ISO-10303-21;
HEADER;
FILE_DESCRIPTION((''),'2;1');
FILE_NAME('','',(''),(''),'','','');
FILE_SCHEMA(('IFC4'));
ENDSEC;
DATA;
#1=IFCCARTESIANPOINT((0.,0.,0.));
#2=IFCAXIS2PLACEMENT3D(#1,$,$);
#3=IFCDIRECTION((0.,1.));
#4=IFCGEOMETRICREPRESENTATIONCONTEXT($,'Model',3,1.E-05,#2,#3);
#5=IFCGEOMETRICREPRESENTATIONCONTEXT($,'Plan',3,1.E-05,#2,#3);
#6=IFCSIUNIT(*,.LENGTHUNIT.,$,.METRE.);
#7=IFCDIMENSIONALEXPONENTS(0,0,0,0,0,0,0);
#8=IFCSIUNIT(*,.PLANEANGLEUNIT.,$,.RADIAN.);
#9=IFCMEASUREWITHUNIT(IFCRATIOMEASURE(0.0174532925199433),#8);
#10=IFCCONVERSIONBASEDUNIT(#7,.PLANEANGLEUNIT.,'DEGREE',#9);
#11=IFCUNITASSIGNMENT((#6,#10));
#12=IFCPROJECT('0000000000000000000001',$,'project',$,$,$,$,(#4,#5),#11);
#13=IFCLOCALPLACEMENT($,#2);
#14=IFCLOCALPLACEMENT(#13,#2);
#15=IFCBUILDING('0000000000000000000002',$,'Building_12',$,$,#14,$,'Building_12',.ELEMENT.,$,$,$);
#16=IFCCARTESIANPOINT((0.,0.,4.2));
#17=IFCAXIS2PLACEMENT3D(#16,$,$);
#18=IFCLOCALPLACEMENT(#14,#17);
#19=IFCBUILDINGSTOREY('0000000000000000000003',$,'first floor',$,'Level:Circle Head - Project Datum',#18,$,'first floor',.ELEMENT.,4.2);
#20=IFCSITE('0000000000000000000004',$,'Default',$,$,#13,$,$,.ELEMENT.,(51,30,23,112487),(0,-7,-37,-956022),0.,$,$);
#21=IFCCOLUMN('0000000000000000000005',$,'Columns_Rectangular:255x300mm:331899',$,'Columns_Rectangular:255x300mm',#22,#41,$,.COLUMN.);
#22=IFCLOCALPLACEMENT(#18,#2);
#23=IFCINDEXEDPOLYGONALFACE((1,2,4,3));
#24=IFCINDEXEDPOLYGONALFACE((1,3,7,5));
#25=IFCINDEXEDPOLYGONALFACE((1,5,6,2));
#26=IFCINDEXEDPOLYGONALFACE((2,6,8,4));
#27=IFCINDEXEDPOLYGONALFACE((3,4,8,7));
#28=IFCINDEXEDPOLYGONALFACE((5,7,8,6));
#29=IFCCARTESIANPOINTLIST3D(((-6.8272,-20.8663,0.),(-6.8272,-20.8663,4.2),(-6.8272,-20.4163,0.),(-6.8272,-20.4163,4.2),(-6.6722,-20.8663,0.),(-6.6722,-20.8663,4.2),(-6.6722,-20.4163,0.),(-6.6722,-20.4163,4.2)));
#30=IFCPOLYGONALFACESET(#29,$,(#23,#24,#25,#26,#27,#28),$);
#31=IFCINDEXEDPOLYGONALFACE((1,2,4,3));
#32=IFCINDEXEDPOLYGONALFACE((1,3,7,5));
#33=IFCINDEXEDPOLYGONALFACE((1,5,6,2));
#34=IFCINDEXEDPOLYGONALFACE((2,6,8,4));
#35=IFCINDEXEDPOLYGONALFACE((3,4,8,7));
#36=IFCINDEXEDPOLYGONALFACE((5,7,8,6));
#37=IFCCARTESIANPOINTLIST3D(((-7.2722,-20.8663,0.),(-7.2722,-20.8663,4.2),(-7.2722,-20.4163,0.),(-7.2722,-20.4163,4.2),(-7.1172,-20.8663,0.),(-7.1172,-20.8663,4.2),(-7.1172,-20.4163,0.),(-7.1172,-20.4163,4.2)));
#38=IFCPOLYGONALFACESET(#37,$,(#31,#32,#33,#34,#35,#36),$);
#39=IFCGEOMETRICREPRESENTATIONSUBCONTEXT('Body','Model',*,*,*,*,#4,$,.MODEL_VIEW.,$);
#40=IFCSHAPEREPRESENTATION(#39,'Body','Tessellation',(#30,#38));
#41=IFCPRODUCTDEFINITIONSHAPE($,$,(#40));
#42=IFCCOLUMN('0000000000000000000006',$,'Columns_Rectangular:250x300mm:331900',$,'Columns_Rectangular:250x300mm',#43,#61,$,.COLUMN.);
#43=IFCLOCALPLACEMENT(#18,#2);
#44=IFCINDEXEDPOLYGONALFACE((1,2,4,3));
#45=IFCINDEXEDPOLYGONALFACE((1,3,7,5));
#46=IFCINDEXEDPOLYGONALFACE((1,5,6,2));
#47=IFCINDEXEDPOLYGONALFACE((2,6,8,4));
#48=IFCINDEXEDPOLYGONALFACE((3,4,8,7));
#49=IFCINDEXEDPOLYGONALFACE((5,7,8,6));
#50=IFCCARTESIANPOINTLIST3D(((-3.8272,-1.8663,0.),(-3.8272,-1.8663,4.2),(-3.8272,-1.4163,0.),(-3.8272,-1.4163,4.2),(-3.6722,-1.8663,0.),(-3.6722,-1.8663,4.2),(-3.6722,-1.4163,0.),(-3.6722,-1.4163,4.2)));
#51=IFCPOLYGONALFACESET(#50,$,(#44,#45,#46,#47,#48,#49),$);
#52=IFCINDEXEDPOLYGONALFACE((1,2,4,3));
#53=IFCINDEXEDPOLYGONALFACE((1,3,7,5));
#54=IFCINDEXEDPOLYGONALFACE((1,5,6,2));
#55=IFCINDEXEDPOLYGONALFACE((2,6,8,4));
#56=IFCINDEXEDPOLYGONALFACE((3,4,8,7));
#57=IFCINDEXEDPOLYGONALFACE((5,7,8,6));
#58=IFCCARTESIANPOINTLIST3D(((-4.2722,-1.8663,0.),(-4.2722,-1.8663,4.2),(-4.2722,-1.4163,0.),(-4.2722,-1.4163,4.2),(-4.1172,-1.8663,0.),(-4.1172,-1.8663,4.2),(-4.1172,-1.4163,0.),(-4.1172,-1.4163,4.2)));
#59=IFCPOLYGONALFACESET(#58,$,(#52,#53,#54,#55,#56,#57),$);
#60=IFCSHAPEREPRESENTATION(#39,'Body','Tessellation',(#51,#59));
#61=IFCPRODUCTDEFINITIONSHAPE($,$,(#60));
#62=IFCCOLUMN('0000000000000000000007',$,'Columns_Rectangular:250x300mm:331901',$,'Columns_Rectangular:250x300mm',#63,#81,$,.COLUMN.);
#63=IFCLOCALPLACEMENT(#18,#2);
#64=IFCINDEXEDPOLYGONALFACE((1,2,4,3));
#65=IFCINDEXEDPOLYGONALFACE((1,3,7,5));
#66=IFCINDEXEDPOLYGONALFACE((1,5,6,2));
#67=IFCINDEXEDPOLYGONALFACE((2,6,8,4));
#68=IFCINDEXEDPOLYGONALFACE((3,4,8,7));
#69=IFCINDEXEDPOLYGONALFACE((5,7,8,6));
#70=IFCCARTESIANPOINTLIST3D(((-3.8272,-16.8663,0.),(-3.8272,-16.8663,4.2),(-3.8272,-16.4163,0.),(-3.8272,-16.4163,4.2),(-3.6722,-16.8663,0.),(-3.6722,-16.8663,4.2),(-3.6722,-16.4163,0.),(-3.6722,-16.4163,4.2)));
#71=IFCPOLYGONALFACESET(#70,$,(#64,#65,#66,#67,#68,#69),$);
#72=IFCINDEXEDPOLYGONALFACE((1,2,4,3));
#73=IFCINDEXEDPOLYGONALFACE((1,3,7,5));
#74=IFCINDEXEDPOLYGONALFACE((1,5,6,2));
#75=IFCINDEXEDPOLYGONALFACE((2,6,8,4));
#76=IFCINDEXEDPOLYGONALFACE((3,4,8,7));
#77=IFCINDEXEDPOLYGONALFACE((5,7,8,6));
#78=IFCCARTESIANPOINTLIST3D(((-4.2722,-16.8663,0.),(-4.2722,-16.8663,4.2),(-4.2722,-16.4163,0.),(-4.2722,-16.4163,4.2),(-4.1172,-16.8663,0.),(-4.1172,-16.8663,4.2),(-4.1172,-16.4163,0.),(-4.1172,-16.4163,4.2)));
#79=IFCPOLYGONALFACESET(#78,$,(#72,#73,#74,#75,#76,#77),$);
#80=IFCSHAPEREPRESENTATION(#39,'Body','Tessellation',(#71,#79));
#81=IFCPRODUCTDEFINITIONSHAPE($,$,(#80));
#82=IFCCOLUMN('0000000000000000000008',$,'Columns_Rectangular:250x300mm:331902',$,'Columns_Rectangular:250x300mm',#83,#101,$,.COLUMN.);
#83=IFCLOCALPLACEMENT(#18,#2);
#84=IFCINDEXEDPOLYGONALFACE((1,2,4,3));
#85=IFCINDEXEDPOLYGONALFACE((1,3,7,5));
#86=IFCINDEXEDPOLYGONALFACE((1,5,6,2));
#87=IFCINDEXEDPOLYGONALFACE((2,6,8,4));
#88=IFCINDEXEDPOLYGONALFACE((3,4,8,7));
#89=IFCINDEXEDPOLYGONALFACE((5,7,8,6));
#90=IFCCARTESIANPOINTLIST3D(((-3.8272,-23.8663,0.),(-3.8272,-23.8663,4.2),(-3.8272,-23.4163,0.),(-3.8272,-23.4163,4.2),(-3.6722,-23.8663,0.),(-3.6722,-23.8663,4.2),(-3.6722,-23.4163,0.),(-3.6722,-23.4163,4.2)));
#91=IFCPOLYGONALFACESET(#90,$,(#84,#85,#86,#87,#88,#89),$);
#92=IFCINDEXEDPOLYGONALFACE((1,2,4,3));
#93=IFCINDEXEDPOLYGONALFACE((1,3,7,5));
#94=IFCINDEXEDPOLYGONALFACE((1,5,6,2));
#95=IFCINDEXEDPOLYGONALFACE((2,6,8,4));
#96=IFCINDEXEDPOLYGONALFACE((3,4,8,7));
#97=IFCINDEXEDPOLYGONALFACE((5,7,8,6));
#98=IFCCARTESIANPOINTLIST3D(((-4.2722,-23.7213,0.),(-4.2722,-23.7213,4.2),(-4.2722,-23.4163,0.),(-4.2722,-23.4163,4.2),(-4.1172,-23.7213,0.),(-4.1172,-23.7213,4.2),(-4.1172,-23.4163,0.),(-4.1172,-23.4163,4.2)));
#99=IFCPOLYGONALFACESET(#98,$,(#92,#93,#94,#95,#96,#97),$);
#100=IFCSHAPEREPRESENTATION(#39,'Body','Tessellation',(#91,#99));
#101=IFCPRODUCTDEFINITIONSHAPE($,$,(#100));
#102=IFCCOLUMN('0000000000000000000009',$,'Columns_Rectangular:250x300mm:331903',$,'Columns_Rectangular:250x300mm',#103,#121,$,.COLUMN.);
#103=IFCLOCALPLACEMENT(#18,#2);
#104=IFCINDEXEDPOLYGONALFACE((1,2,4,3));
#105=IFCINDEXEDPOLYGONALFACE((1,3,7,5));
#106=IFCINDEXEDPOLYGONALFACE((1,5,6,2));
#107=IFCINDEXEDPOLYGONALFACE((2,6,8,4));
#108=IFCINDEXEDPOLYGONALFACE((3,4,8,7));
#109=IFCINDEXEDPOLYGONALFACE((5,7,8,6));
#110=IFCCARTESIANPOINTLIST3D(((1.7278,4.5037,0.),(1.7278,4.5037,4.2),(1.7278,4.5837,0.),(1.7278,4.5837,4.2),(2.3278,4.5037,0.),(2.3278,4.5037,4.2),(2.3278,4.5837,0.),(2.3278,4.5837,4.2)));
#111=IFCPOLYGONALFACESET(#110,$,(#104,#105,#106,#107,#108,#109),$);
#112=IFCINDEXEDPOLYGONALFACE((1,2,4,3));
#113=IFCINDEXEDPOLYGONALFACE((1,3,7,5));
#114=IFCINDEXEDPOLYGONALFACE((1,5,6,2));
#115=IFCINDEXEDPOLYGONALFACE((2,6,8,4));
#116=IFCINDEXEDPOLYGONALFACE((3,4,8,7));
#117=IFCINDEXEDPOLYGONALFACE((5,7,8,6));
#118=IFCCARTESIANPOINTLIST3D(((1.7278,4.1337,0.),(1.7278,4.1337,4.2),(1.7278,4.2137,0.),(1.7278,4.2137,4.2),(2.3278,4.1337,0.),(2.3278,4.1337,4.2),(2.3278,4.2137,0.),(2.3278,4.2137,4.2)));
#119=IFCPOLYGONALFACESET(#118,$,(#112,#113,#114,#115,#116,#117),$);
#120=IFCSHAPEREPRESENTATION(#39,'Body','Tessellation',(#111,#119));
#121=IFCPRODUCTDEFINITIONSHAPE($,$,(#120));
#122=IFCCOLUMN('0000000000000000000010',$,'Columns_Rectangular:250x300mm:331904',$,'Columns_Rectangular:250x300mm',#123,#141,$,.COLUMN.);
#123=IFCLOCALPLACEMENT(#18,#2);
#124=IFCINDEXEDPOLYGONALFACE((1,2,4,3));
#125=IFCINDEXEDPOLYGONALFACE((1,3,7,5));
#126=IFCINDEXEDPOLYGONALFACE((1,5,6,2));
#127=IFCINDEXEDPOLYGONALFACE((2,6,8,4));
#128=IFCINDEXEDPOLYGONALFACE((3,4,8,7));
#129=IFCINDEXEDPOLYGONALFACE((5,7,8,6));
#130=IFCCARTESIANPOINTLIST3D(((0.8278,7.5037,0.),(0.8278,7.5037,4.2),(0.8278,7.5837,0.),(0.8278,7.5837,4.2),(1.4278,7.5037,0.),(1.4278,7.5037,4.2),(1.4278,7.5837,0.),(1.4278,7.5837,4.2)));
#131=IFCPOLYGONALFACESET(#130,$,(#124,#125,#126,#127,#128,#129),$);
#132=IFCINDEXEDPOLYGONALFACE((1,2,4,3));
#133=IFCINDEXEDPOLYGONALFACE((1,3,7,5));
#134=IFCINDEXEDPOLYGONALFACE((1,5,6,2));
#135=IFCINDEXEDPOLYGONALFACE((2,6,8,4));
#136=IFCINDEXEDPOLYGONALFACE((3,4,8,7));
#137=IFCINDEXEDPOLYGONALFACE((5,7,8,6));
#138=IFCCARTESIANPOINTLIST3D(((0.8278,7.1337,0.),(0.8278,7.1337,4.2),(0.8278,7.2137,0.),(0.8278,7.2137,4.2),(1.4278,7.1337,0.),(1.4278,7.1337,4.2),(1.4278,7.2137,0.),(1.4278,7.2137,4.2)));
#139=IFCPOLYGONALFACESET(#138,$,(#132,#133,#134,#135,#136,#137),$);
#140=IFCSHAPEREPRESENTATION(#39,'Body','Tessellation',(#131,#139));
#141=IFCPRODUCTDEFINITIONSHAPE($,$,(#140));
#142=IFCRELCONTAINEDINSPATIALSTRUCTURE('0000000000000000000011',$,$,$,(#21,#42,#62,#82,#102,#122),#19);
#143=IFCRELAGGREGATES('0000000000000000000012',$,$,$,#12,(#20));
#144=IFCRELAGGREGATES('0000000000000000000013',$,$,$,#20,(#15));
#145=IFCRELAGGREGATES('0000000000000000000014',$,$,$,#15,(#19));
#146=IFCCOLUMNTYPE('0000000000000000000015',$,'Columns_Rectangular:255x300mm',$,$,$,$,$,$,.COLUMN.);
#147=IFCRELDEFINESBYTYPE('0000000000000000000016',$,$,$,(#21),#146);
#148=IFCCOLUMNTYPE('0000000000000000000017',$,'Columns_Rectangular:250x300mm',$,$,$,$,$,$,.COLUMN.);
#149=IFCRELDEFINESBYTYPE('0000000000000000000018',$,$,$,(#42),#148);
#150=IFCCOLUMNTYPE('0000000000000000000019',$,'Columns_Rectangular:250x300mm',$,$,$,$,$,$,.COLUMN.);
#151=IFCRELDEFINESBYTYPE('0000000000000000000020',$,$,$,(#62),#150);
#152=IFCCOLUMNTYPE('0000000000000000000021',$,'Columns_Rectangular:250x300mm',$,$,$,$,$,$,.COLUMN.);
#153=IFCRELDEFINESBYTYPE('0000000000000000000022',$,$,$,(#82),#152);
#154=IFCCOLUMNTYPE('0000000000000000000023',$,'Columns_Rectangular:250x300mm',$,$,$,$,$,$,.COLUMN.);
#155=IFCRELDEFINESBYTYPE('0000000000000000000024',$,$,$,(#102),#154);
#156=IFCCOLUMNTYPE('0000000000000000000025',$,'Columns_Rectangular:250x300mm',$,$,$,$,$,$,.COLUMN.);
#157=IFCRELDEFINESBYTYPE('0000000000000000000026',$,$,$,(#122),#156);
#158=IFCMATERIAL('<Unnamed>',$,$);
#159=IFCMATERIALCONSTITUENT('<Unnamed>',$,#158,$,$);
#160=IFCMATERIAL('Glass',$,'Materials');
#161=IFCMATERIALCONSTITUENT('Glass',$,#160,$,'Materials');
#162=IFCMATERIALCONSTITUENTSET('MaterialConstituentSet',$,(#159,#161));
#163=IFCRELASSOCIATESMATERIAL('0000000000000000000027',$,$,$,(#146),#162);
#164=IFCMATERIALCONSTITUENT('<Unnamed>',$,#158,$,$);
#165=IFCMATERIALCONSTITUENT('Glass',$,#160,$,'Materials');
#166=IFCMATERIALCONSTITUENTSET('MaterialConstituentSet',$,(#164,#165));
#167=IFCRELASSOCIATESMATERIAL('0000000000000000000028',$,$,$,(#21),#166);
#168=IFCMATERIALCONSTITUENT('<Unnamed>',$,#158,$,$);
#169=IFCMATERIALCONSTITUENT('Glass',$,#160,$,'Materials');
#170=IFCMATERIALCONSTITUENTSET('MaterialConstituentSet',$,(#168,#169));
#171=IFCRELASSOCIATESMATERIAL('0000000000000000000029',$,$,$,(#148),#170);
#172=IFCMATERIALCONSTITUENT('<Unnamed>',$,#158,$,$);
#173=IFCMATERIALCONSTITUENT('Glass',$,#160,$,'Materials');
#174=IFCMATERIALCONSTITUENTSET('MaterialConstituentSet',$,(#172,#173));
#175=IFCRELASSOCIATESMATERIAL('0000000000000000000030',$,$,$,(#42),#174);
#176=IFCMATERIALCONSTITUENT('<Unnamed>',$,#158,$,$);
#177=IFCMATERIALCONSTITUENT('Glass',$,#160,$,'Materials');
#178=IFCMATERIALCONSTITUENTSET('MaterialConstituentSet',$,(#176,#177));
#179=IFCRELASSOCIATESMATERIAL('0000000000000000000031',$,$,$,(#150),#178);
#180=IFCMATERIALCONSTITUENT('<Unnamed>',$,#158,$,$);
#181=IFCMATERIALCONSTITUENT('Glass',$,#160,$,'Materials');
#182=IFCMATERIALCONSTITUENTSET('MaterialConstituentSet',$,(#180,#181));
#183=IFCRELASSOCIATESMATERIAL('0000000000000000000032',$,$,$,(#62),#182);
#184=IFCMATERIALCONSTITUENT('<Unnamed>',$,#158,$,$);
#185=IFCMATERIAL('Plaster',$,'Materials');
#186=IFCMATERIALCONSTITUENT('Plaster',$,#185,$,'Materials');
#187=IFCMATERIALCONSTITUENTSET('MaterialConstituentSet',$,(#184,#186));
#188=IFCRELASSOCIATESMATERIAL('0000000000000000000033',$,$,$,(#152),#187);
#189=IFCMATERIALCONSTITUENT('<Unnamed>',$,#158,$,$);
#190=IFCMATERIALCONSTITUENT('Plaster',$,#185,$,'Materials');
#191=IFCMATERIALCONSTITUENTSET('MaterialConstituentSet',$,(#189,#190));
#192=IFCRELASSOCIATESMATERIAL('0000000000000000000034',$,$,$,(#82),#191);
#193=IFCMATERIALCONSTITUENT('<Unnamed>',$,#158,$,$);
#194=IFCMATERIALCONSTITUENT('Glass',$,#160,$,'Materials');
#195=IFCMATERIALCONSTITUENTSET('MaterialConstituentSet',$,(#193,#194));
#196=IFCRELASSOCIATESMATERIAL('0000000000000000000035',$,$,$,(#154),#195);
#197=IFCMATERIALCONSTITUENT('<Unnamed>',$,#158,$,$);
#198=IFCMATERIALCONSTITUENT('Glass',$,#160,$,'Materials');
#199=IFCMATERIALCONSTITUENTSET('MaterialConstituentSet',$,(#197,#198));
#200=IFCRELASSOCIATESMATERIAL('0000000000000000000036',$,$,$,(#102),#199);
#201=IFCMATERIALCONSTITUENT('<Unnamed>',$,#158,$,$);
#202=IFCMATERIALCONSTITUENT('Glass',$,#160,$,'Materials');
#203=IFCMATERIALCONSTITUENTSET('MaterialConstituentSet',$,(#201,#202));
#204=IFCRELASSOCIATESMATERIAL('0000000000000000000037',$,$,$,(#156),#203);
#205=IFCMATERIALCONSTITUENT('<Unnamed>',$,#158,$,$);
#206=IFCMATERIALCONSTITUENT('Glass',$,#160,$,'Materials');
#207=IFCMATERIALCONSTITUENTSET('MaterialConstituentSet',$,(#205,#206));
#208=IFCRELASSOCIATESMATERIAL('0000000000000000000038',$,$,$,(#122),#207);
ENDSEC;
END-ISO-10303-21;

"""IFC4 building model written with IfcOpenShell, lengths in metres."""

from ifc_helpers import new_model, entity, si_unit, converted_unit, direction, frame, origin, place, context, subcontext, project, spatial, indexed_curve, outline, extrude, source, transform, mapped, material, constituent, constituent_set, type_object, type_shapes, element, save


model = new_model("IFC4")

# Units and contexts
model_context = context("Model", 3, precision=1e-05, world=origin(), true_north=direction((0.0, 1.0)))
plan_context = context("Plan", 3, precision=1e-05, world=origin(), true_north=direction((0.0, 1.0)))
body_context = subcontext(model_context, "Body", "Model", "MODEL_VIEW")
ifc_project = project(units=[si_unit("LENGTHUNIT", "METRE"), converted_unit("PLANEANGLEUNIT", "DEGREE", entity("IfcRatioMeasure", 0.0174532925199433), si_unit("PLANEANGLEUNIT", "RADIAN"), dimensions=[0, 0, 0, 0, 0, 0, 0])], contexts=[model_context, plan_context])

# Site, building, storey
site_placement = place(None, origin())
site = spatial("IfcSite", under=ifc_project, at=site_placement, Name="Default", CompositionType="ELEMENT", RefLatitude=(51, 30, 23, 112487), RefLongitude=(0, -7, -37, -956022), RefElevation=0.0)
building_placement = place(site_placement, origin())
building = spatial("IfcBuilding", under=site, at=building_placement, Name="Building_12", LongName="Building_12", CompositionType="ELEMENT")
storey_placement = place(building_placement, frame((0.0, 0.0, 4.2)))
storey = spatial("IfcBuildingStorey", under=building, at=storey_placement, Name="first floor", ObjectType="Level:Circle Head - Project Datum", LongName="first floor", CompositionType="ELEMENT", Elevation=4.2)

# Columns
ifc_material_1 = material(Name="<Unnamed>")
ifc_constituent_1 = constituent(ifc_material_1, Name="<Unnamed>")
ifc_material_2 = material(Name="Glass", Category="Materials")
ifc_constituent_2 = constituent(ifc_material_2, Name="Glass", Category="Materials")
ifc_constituent_set_1 = constituent_set(constituents=[ifc_constituent_1, ifc_constituent_2], Name="MaterialConstituentSet")
ifc_constituent_3 = constituent(ifc_material_1, Name="<Unnamed>")
ifc_constituent_4 = constituent(ifc_material_2, Name="Glass", Category="Materials")
ifc_constituent_set_2 = constituent_set(constituents=[ifc_constituent_3, ifc_constituent_4], Name="MaterialConstituentSet")
column_type_1 = type_object("IfcColumnType", Name="Columns_Rectangular:255x300mm", PredefinedType="COLUMN", material=ifc_constituent_set_2)
shared_shape_1 = source(origin(), body_context, "Body", "SweptSolid", [
    extrude(outline(indexed_curve([(-0.225, -0.0775), (0.225, -0.0775), (0.225, 0.0775), (-0.225, 0.0775), (-0.225, -0.0775)], self_intersect=False)), frame((-6.7497, -20.6413, 4.2), z_axis=(0.0, 0.0, 1.0), x_axis=(0.0, -1.0, 0.0)), (0.0, 0.0, 1.0), 4.2),
    extrude(outline(indexed_curve([(-0.225, -0.0775), (0.225, -0.0775), (0.225, 0.0775), (-0.225, 0.0775), (-0.225, -0.0775)], self_intersect=False)), frame((-7.1947, -20.6413, 4.2), z_axis=(0.0, 0.0, 1.0), x_axis=(0.0, -1.0, 0.0)), (0.0, 0.0, 1.0), 4.2),
])
type_shapes(column_type_1, [shared_shape_1])
column_1_placement = place(storey_placement, frame((0.0, 0.0, -4.2)))
element("IfcColumn", 1, at=column_1_placement, inside=storey, type_object=column_type_1, material=ifc_constituent_set_1, Name="Columns_Rectangular:255x300mm:331899", ObjectType="Columns_Rectangular:255x300mm", PredefinedType="COLUMN", context=body_context, shape_type="MappedRepresentation", body=[
    mapped(shared_shape_1, transform((0.0, 0.0, 0.0), scale=1.0)),
])
ifc_constituent_5 = constituent(ifc_material_1, Name="<Unnamed>")
ifc_constituent_6 = constituent(ifc_material_2, Name="Glass", Category="Materials")
ifc_constituent_set_3 = constituent_set(constituents=[ifc_constituent_5, ifc_constituent_6], Name="MaterialConstituentSet")
ifc_constituent_7 = constituent(ifc_material_1, Name="<Unnamed>")
ifc_constituent_8 = constituent(ifc_material_2, Name="Glass", Category="Materials")
ifc_constituent_set_4 = constituent_set(constituents=[ifc_constituent_7, ifc_constituent_8], Name="MaterialConstituentSet")
column_type_2 = type_object("IfcColumnType", Name="Columns_Rectangular:250x300mm", PredefinedType="COLUMN", material=ifc_constituent_set_4)
shared_shape_2 = source(origin(), body_context, "Body", "SweptSolid", [
    extrude(outline(indexed_curve([(-0.225, -0.0775), (0.225, -0.0775), (0.225, 0.0775), (-0.225, 0.0775), (-0.225, -0.0775)], self_intersect=False)), frame((-3.7497, -1.6413, 4.2), z_axis=(0.0, 0.0, 1.0), x_axis=(0.0, -1.0, 0.0)), (0.0, 0.0, 1.0), 4.2),
    extrude(outline(indexed_curve([(-0.225, -0.0775), (0.225, -0.0775), (0.225, 0.0775), (-0.225, 0.0775), (-0.225, -0.0775)], self_intersect=False)), frame((-4.1947, -1.6413, 4.2), z_axis=(0.0, 0.0, 1.0), x_axis=(0.0, -1.0, 0.0)), (0.0, 0.0, 1.0), 4.2),
])
type_shapes(column_type_2, [shared_shape_2])
column_2_placement = place(storey_placement, frame((0.0, 0.0, -4.2)))
element("IfcColumn", 2, at=column_2_placement, inside=storey, type_object=column_type_2, material=ifc_constituent_set_3, Name="Columns_Rectangular:250x300mm:331900", ObjectType="Columns_Rectangular:250x300mm", PredefinedType="COLUMN", context=body_context, shape_type="MappedRepresentation", body=[
    mapped(shared_shape_2, transform((0.0, 0.0, 0.0), scale=1.0)),
])
ifc_constituent_9 = constituent(ifc_material_1, Name="<Unnamed>")
ifc_constituent_10 = constituent(ifc_material_2, Name="Glass", Category="Materials")
ifc_constituent_set_5 = constituent_set(constituents=[ifc_constituent_9, ifc_constituent_10], Name="MaterialConstituentSet")
ifc_constituent_11 = constituent(ifc_material_1, Name="<Unnamed>")
ifc_constituent_12 = constituent(ifc_material_2, Name="Glass", Category="Materials")
ifc_constituent_set_6 = constituent_set(constituents=[ifc_constituent_11, ifc_constituent_12], Name="MaterialConstituentSet")
column_type_3 = type_object("IfcColumnType", Name="Columns_Rectangular:250x300mm", PredefinedType="COLUMN", material=ifc_constituent_set_6)
shared_shape_3 = source(origin(), body_context, "Body", "SweptSolid", [
    extrude(outline(indexed_curve([(-0.225, -0.0775), (0.225, -0.0775), (0.225, 0.0775), (-0.225, 0.0775), (-0.225, -0.0775)], self_intersect=False)), frame((-3.7497, -16.6413, 4.2), z_axis=(0.0, 0.0, 1.0), x_axis=(0.0, -1.0, 0.0)), (0.0, 0.0, 1.0), 4.2),
    extrude(outline(indexed_curve([(-0.225, -0.0775), (0.225, -0.0775), (0.225, 0.0775), (-0.225, 0.0775), (-0.225, -0.0775)], self_intersect=False)), frame((-4.1947, -16.6413, 4.2), z_axis=(0.0, 0.0, 1.0), x_axis=(0.0, -1.0, 0.0)), (0.0, 0.0, 1.0), 4.2),
])
type_shapes(column_type_3, [shared_shape_3])
column_3_placement = place(storey_placement, frame((0.0, 0.0, -4.2)))
element("IfcColumn", 3, at=column_3_placement, inside=storey, type_object=column_type_3, material=ifc_constituent_set_5, Name="Columns_Rectangular:250x300mm:331901", ObjectType="Columns_Rectangular:250x300mm", PredefinedType="COLUMN", context=body_context, shape_type="MappedRepresentation", body=[
    mapped(shared_shape_3, transform((0.0, 0.0, 0.0), scale=1.0)),
])
ifc_constituent_13 = constituent(ifc_material_1, Name="<Unnamed>")
ifc_material_3 = material(Name="Plaster", Category="Materials")
ifc_constituent_14 = constituent(ifc_material_3, Name="Plaster", Category="Materials")
ifc_constituent_set_7 = constituent_set(constituents=[ifc_constituent_13, ifc_constituent_14], Name="MaterialConstituentSet")
ifc_constituent_15 = constituent(ifc_material_1, Name="<Unnamed>")
ifc_constituent_16 = constituent(ifc_material_3, Name="Plaster", Category="Materials")
ifc_constituent_set_8 = constituent_set(constituents=[ifc_constituent_15, ifc_constituent_16], Name="MaterialConstituentSet")
column_type_4 = type_object("IfcColumnType", Name="Columns_Rectangular:250x300mm", PredefinedType="COLUMN", material=ifc_constituent_set_8)
shared_shape_4 = source(origin(), body_context, "Body", "SweptSolid", [
    extrude(outline(indexed_curve([(-0.225, -0.0775), (0.225, -0.0775), (0.225, 0.0775), (-0.225, 0.0775), (-0.225, -0.0775)], self_intersect=False)), frame((-3.7497, -23.6413, 4.2), z_axis=(0.0, 0.0, 1.0), x_axis=(0.0, -1.0, 0.0)), (0.0, 0.0, 1.0), 4.2),
    extrude(outline(indexed_curve([(-0.1525, -0.0775), (0.1525, -0.0775), (0.1525, 0.0775), (-0.1525, 0.0775), (-0.1525, -0.0775)], self_intersect=False)), frame((-4.1947, -23.5688, 4.2), z_axis=(0.0, 0.0, 1.0), x_axis=(0.0, -1.0, 0.0)), (0.0, 0.0, 1.0), 4.2),
])
type_shapes(column_type_4, [shared_shape_4])
column_4_placement = place(storey_placement, frame((0.0, 0.0, -4.2)))
element("IfcColumn", 4, at=column_4_placement, inside=storey, type_object=column_type_4, material=ifc_constituent_set_7, Name="Columns_Rectangular:250x300mm:331902", ObjectType="Columns_Rectangular:250x300mm", PredefinedType="COLUMN", context=body_context, shape_type="MappedRepresentation", body=[
    mapped(shared_shape_4, transform((0.0, 0.0, 0.0), scale=1.0)),
])
ifc_constituent_17 = constituent(ifc_material_1, Name="<Unnamed>")
ifc_constituent_18 = constituent(ifc_material_2, Name="Glass", Category="Materials")
ifc_constituent_set_9 = constituent_set(constituents=[ifc_constituent_17, ifc_constituent_18], Name="MaterialConstituentSet")
ifc_constituent_19 = constituent(ifc_material_1, Name="<Unnamed>")
ifc_constituent_20 = constituent(ifc_material_2, Name="Glass", Category="Materials")
ifc_constituent_set_10 = constituent_set(constituents=[ifc_constituent_19, ifc_constituent_20], Name="MaterialConstituentSet")
column_type_5 = type_object("IfcColumnType", Name="Columns_Rectangular:250x300mm", PredefinedType="COLUMN", material=ifc_constituent_set_10)
shared_shape_5 = source(origin(), body_context, "Body", "SweptSolid", [
    extrude(outline(indexed_curve([(-0.04, -0.3), (0.04, -0.3), (0.04, 0.3), (-0.04, 0.3), (-0.04, -0.3)], self_intersect=False)), frame((2.0278, 4.5437, 4.2), z_axis=(0.0, 0.0, 1.0), x_axis=(0.0, -1.0, 0.0)), (0.0, 0.0, 1.0), 4.2),
    extrude(outline(indexed_curve([(-0.04, -0.3), (0.04, -0.3), (0.04, 0.3), (-0.04, 0.3), (-0.04, -0.3)], self_intersect=False)), frame((2.0278, 4.1737, 4.2), z_axis=(0.0, 0.0, 1.0), x_axis=(0.0, -1.0, 0.0)), (0.0, 0.0, 1.0), 4.2),
])
type_shapes(column_type_5, [shared_shape_5])
column_5_placement = place(storey_placement, frame((0.0, 0.0, -4.2)))
element("IfcColumn", 5, at=column_5_placement, inside=storey, type_object=column_type_5, material=ifc_constituent_set_9, Name="Columns_Rectangular:250x300mm:331903", ObjectType="Columns_Rectangular:250x300mm", PredefinedType="COLUMN", context=body_context, shape_type="MappedRepresentation", body=[
    mapped(shared_shape_5, transform((0.0, 0.0, 0.0), scale=1.0)),
])
ifc_constituent_21 = constituent(ifc_material_1, Name="<Unnamed>")
ifc_constituent_22 = constituent(ifc_material_2, Name="Glass", Category="Materials")
ifc_constituent_set_11 = constituent_set(constituents=[ifc_constituent_21, ifc_constituent_22], Name="MaterialConstituentSet")
ifc_constituent_23 = constituent(ifc_material_1, Name="<Unnamed>")
ifc_constituent_24 = constituent(ifc_material_2, Name="Glass", Category="Materials")
ifc_constituent_set_12 = constituent_set(constituents=[ifc_constituent_23, ifc_constituent_24], Name="MaterialConstituentSet")
column_type_6 = type_object("IfcColumnType", Name="Columns_Rectangular:250x300mm", PredefinedType="COLUMN", material=ifc_constituent_set_12)
shared_shape_6 = source(origin(), body_context, "Body", "SweptSolid", [
    extrude(outline(indexed_curve([(-0.04, -0.3), (0.04, -0.3), (0.04, 0.3), (-0.04, 0.3), (-0.04, -0.3)], self_intersect=False)), frame((1.1278, 7.5437, 4.2), z_axis=(0.0, 0.0, 1.0), x_axis=(0.0, -1.0, 0.0)), (0.0, 0.0, 1.0), 4.2),
    extrude(outline(indexed_curve([(-0.04, -0.3), (0.04, -0.3), (0.04, 0.3), (-0.04, 0.3), (-0.04, -0.3)], self_intersect=False)), frame((1.1278, 7.1737, 4.2), z_axis=(0.0, 0.0, 1.0), x_axis=(0.0, -1.0, 0.0)), (0.0, 0.0, 1.0), 4.2),
])
type_shapes(column_type_6, [shared_shape_6])
column_6_placement = place(storey_placement, frame((0.0, 0.0, -4.2)))
element("IfcColumn", 6, at=column_6_placement, inside=storey, type_object=column_type_6, material=ifc_constituent_set_11, Name="Columns_Rectangular:250x300mm:331904", ObjectType="Columns_Rectangular:250x300mm", PredefinedType="COLUMN", context=body_context, shape_type="MappedRepresentation", body=[
    mapped(shared_shape_6, transform((0.0, 0.0, 0.0), scale=1.0)),
])

save(model, "model.ifc")
